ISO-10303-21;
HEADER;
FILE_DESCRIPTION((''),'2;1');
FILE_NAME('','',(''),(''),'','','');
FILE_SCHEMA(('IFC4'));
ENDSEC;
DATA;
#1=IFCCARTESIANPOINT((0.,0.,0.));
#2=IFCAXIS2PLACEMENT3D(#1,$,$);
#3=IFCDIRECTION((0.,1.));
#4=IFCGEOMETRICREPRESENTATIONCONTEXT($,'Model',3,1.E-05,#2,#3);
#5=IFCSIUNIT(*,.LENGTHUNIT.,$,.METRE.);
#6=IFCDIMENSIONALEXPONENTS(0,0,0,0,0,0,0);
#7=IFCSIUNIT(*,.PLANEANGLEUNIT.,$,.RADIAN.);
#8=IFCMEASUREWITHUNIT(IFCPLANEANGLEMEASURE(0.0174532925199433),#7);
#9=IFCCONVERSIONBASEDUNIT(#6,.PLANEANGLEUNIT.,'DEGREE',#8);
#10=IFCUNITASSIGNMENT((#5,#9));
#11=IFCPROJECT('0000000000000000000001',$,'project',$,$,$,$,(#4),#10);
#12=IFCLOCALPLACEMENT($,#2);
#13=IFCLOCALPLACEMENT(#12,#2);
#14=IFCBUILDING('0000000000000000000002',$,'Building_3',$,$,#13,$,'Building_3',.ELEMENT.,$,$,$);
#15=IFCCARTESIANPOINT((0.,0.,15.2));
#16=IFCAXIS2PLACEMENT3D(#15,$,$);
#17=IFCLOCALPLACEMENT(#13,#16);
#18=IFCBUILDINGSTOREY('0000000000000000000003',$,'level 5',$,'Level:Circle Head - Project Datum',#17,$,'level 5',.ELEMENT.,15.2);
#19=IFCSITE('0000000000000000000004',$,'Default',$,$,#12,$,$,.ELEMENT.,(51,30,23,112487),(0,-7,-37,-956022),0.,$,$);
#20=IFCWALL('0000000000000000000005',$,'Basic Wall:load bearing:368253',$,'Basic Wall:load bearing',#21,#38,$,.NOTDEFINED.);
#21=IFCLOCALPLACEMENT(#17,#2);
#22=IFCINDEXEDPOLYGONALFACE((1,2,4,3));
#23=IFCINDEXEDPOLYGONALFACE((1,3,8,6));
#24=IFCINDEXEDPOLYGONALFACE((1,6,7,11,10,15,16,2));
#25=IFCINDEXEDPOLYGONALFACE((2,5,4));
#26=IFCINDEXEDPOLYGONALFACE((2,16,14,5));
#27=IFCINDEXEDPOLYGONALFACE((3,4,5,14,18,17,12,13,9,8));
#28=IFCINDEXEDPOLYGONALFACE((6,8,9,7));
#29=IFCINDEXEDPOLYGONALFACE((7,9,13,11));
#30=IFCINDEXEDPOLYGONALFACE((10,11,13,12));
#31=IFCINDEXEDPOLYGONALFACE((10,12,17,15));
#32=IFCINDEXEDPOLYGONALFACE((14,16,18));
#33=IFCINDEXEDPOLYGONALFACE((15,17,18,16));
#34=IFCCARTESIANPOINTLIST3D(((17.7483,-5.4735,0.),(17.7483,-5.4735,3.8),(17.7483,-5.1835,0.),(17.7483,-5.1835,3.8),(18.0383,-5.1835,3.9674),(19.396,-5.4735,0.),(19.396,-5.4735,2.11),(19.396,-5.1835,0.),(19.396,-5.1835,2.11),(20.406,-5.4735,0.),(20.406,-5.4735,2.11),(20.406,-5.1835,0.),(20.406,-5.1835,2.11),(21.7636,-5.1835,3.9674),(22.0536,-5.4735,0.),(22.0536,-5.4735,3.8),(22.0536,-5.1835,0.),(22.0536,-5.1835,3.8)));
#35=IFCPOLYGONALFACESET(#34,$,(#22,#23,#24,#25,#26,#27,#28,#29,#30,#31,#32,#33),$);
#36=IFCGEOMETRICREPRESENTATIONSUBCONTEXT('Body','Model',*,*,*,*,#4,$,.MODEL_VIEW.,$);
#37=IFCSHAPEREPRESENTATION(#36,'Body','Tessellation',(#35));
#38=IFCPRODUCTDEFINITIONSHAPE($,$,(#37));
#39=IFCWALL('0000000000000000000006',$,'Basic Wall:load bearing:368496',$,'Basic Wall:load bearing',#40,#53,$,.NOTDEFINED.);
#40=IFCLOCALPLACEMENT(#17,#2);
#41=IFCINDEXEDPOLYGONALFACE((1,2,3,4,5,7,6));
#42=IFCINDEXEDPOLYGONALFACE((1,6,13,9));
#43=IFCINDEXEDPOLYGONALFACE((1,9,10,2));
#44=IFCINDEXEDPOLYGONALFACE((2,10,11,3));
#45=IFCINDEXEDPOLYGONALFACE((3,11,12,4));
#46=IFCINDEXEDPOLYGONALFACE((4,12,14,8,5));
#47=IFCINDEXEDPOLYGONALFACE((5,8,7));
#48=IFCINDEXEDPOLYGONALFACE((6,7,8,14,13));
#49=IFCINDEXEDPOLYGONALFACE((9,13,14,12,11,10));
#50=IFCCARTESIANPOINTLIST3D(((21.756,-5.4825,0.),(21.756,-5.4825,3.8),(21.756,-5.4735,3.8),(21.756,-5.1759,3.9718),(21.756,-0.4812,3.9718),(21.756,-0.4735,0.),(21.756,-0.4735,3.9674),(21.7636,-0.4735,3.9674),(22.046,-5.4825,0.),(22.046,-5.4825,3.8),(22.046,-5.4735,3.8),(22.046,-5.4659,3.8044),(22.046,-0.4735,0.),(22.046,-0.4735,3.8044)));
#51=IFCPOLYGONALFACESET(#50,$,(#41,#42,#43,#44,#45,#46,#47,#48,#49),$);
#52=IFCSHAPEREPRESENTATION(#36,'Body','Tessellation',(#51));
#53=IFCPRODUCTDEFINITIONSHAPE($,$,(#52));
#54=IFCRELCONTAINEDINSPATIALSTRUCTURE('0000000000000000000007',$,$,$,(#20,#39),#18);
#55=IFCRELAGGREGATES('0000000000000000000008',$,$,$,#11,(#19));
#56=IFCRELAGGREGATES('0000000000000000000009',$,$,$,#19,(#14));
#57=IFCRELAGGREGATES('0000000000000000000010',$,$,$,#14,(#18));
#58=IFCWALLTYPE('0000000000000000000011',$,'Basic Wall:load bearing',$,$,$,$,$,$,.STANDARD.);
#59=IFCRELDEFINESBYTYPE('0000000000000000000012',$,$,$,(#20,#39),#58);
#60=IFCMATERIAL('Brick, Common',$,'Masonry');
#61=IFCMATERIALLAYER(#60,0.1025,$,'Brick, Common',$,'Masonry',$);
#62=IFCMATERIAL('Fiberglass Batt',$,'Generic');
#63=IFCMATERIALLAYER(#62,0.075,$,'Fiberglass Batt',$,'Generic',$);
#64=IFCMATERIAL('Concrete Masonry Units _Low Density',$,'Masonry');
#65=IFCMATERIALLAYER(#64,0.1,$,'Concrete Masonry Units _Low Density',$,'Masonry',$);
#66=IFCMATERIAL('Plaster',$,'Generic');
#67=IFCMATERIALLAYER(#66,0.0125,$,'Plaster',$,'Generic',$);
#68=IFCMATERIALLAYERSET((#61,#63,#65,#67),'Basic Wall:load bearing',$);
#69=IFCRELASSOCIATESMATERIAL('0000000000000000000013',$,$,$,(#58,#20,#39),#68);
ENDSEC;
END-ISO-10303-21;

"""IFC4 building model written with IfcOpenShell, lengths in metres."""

from ifc_helpers import new_model, entity, si_unit, converted_unit, direction, frame, frame_2d, origin, place, context, subcontext, project, spatial, polyline, rectangle, extrude, clip, bounded_halfspace, material, layer, layer_set, layer_usage, type_object, element, save


model = new_model("IFC4")

# Units and contexts
model_context = context("Model", 3, precision=1e-05, world=origin(), true_north=direction((0.0, 1.0)))
body_context = subcontext(model_context, "Body", "Model", "MODEL_VIEW")
ifc_project = project(units=[si_unit("LENGTHUNIT", "METRE"), converted_unit("PLANEANGLEUNIT", "DEGREE", entity("IfcPlaneAngleMeasure", 0.0174532925199433), si_unit("PLANEANGLEUNIT", "RADIAN"), dimensions=[0, 0, 0, 0, 0, 0, 0])], contexts=[model_context])

# Site, building, storey
site_placement = place(None, origin())
site = spatial("IfcSite", under=ifc_project, at=site_placement, Name="Default", CompositionType="ELEMENT", RefLatitude=(51, 30, 23, 112487), RefLongitude=(0, -7, -37, -956022), RefElevation=0.0)
building_placement = place(site_placement, origin())
building = spatial("IfcBuilding", under=site, at=building_placement, Name="Building_3", LongName="Building_3", CompositionType="ELEMENT")
storey_placement = place(building_placement, frame((0.0, 0.0, 15.2)))
storey = spatial("IfcBuildingStorey", under=building, at=storey_placement, Name="level 5", ObjectType="Level:Circle Head - Project Datum", LongName="level 5", CompositionType="ELEMENT", Elevation=15.2)

# Shared definitions
ifc_material_1 = material(Name="Brick, Common", Category="Masonry")
ifc_layer_1 = layer(ifc_material_1, 0.1025, Name="Brick, Common", Category="Masonry")
ifc_material_2 = material(Name="Fiberglass Batt", Category="Generic")
ifc_layer_2 = layer(ifc_material_2, 0.075, Name="Fiberglass Batt", Category="Generic")
ifc_material_3 = material(Name="Concrete Masonry Units _Low Density", Category="Masonry")
ifc_layer_3 = layer(ifc_material_3, 0.1, Name="Concrete Masonry Units _Low Density", Category="Masonry")
ifc_material_4 = material(Name="Plaster", Category="Generic")
ifc_layer_4 = layer(ifc_material_4, 0.0125, Name="Plaster", Category="Generic")
ifc_layer_set_1 = layer_set([ifc_layer_1, ifc_layer_2, ifc_layer_3, ifc_layer_4], Name="Basic Wall:load bearing")
wall_type = type_object("IfcWallType", Name="Basic Wall:load bearing", PredefinedType="STANDARD", material=ifc_layer_set_1)

# Wall, opening
ifc_layer_usage_1 = layer_usage(ifc_layer_set_1, "AXIS2", "NEGATIVE", 0.145)
wall_1_placement = place(storey_placement, frame((17.7483, -5.3285, 0.0)))
wall_1 = element("IfcWall", 1, at=wall_1_placement, inside=storey, type_object=wall_type, material=ifc_layer_usage_1, Name="Basic Wall:load bearing:368253", ObjectType="Basic Wall:load bearing", PredefinedType="NOTDEFINED", context=body_context, shape_type="Clipping", body=[
    clip(clip(clip(extrude(rectangle(XDim=0.29, YDim=4.3053, at=frame_2d((2.1526, 0.0), x_axis=(0.0, 1.0))), origin(), (0.0, 0.0, 1.0), 3.9674), bounded_halfspace(frame((4.3053, -0.145, 3.8), z_axis=(0.5, 0.0, 0.866025), x_axis=(0.0, 1.0, 0.0)), False, frame((4.3053, -0.145, 3.8)), polyline([(0.0, 0.0), (0.0, 0.29), (-0.29, 0.29), (0.0, 0.0)]))), bounded_halfspace(frame((0.0, -0.145, 3.8), z_axis=(0.0, -0.5, 0.866025), x_axis=(1.0, 0.0, 0.0)), False, frame((0.0, -0.145, 3.8)), polyline([(0.0, 0.0), (4.3053, 0.0), (4.0153, 0.29), (0.29, 0.29), (0.0, 0.0)]))), bounded_halfspace(frame((0.0, 0.145, 3.8), z_axis=(-0.5, 0.0, 0.866025), x_axis=(0.0, -1.0, 0.0)), False, frame((0.0, 0.145, 3.8)), polyline([(0.0, 0.0), (0.0, -0.29), (0.29, 0.0), (0.0, 0.0)]))),
])
opening_1_placement = place(wall_1_placement, frame((2.6576, 0.145, 0.0)))
element("IfcOpeningElement", 2, at=opening_1_placement, cuts=wall_1, PredefinedType="OPENING", context=body_context, shape_type="SweptSolid", body=[
    extrude(rectangle(XDim=2.11, YDim=1.01, at=frame_2d((1.055, 0.505), x_axis=(1.0, 0.0))), frame((0.0, 0.0, 0.0), z_axis=(0.0, -1.0, 0.0), x_axis=(0.0, 0.0, 1.0)), (0.0, 0.0, 1.0), 0.29),
])

# Wall
ifc_layer_usage_2 = layer_usage(ifc_layer_set_1, "AXIS2", "NEGATIVE", 0.145)
wall_2_placement = place(storey_placement, frame((21.901, -5.4825, 0.0), z_axis=(0.0, 0.0, 1.0), x_axis=(0.0, 1.0, 0.0)))
element("IfcWall", 3, at=wall_2_placement, inside=storey, type_object=wall_type, material=ifc_layer_usage_2, Name="Basic Wall:load bearing:368496", ObjectType="Basic Wall:load bearing", PredefinedType="NOTDEFINED", context=body_context, shape_type="Clipping", body=[
    clip(clip(clip(clip(extrude(rectangle(XDim=5.0089, YDim=0.29, at=frame_2d((2.5045, 0.0), x_axis=(-1.0, 0.0))), origin(), (0.0, 0.0, 1.0), 3.9718), bounded_halfspace(frame((5.0089, 0.1373, 3.9674), z_axis=(0.5, 0.0, 0.866025), x_axis=(0.0, 1.0, 0.0)), False, frame((5.0089, 0.1373, 3.9674)), polyline([(0.0, 0.0), (0.0, 0.0077), (-0.0077, 0.0077), (0.0, 0.0)]))), bounded_halfspace(frame((0.0166, -0.145, 3.8044), z_axis=(0.0, -0.5, 0.866025), x_axis=(1.0, 0.0, 0.0)), False, frame((0.0166, -0.145, 3.8044)), polyline([(0.0, 0.0), (4.9924, 0.0), (4.9924, 0.2823), (4.9847, 0.29), (0.29, 0.29), (0.0, 0.0)]))), bounded_halfspace(frame((0.0089, -0.145, 3.8), z_axis=(-0.5, 0.0, 0.866025), x_axis=(0.0, -1.0, 0.0)), False, frame((0.0089, -0.145, 3.8)), polyline([(0.0, 0.0), (0.0077, 0.0), (0.2977, 0.29), (0.0, 0.29), (0.0, 0.0)]))), bounded_halfspace(frame((0.0, -0.145, 3.8), z_axis=(0.0, 0.0, 1.0), x_axis=(0.0, 1.0, 0.0)), False, frame((0.0, -0.145, 3.8)), polyline([(0.0, 0.0), (0.0089, 0.0), (0.0089, 0.29), (0.0, 0.29), (0.0, 0.0)]))),
])

save(model, "model.ifc")
